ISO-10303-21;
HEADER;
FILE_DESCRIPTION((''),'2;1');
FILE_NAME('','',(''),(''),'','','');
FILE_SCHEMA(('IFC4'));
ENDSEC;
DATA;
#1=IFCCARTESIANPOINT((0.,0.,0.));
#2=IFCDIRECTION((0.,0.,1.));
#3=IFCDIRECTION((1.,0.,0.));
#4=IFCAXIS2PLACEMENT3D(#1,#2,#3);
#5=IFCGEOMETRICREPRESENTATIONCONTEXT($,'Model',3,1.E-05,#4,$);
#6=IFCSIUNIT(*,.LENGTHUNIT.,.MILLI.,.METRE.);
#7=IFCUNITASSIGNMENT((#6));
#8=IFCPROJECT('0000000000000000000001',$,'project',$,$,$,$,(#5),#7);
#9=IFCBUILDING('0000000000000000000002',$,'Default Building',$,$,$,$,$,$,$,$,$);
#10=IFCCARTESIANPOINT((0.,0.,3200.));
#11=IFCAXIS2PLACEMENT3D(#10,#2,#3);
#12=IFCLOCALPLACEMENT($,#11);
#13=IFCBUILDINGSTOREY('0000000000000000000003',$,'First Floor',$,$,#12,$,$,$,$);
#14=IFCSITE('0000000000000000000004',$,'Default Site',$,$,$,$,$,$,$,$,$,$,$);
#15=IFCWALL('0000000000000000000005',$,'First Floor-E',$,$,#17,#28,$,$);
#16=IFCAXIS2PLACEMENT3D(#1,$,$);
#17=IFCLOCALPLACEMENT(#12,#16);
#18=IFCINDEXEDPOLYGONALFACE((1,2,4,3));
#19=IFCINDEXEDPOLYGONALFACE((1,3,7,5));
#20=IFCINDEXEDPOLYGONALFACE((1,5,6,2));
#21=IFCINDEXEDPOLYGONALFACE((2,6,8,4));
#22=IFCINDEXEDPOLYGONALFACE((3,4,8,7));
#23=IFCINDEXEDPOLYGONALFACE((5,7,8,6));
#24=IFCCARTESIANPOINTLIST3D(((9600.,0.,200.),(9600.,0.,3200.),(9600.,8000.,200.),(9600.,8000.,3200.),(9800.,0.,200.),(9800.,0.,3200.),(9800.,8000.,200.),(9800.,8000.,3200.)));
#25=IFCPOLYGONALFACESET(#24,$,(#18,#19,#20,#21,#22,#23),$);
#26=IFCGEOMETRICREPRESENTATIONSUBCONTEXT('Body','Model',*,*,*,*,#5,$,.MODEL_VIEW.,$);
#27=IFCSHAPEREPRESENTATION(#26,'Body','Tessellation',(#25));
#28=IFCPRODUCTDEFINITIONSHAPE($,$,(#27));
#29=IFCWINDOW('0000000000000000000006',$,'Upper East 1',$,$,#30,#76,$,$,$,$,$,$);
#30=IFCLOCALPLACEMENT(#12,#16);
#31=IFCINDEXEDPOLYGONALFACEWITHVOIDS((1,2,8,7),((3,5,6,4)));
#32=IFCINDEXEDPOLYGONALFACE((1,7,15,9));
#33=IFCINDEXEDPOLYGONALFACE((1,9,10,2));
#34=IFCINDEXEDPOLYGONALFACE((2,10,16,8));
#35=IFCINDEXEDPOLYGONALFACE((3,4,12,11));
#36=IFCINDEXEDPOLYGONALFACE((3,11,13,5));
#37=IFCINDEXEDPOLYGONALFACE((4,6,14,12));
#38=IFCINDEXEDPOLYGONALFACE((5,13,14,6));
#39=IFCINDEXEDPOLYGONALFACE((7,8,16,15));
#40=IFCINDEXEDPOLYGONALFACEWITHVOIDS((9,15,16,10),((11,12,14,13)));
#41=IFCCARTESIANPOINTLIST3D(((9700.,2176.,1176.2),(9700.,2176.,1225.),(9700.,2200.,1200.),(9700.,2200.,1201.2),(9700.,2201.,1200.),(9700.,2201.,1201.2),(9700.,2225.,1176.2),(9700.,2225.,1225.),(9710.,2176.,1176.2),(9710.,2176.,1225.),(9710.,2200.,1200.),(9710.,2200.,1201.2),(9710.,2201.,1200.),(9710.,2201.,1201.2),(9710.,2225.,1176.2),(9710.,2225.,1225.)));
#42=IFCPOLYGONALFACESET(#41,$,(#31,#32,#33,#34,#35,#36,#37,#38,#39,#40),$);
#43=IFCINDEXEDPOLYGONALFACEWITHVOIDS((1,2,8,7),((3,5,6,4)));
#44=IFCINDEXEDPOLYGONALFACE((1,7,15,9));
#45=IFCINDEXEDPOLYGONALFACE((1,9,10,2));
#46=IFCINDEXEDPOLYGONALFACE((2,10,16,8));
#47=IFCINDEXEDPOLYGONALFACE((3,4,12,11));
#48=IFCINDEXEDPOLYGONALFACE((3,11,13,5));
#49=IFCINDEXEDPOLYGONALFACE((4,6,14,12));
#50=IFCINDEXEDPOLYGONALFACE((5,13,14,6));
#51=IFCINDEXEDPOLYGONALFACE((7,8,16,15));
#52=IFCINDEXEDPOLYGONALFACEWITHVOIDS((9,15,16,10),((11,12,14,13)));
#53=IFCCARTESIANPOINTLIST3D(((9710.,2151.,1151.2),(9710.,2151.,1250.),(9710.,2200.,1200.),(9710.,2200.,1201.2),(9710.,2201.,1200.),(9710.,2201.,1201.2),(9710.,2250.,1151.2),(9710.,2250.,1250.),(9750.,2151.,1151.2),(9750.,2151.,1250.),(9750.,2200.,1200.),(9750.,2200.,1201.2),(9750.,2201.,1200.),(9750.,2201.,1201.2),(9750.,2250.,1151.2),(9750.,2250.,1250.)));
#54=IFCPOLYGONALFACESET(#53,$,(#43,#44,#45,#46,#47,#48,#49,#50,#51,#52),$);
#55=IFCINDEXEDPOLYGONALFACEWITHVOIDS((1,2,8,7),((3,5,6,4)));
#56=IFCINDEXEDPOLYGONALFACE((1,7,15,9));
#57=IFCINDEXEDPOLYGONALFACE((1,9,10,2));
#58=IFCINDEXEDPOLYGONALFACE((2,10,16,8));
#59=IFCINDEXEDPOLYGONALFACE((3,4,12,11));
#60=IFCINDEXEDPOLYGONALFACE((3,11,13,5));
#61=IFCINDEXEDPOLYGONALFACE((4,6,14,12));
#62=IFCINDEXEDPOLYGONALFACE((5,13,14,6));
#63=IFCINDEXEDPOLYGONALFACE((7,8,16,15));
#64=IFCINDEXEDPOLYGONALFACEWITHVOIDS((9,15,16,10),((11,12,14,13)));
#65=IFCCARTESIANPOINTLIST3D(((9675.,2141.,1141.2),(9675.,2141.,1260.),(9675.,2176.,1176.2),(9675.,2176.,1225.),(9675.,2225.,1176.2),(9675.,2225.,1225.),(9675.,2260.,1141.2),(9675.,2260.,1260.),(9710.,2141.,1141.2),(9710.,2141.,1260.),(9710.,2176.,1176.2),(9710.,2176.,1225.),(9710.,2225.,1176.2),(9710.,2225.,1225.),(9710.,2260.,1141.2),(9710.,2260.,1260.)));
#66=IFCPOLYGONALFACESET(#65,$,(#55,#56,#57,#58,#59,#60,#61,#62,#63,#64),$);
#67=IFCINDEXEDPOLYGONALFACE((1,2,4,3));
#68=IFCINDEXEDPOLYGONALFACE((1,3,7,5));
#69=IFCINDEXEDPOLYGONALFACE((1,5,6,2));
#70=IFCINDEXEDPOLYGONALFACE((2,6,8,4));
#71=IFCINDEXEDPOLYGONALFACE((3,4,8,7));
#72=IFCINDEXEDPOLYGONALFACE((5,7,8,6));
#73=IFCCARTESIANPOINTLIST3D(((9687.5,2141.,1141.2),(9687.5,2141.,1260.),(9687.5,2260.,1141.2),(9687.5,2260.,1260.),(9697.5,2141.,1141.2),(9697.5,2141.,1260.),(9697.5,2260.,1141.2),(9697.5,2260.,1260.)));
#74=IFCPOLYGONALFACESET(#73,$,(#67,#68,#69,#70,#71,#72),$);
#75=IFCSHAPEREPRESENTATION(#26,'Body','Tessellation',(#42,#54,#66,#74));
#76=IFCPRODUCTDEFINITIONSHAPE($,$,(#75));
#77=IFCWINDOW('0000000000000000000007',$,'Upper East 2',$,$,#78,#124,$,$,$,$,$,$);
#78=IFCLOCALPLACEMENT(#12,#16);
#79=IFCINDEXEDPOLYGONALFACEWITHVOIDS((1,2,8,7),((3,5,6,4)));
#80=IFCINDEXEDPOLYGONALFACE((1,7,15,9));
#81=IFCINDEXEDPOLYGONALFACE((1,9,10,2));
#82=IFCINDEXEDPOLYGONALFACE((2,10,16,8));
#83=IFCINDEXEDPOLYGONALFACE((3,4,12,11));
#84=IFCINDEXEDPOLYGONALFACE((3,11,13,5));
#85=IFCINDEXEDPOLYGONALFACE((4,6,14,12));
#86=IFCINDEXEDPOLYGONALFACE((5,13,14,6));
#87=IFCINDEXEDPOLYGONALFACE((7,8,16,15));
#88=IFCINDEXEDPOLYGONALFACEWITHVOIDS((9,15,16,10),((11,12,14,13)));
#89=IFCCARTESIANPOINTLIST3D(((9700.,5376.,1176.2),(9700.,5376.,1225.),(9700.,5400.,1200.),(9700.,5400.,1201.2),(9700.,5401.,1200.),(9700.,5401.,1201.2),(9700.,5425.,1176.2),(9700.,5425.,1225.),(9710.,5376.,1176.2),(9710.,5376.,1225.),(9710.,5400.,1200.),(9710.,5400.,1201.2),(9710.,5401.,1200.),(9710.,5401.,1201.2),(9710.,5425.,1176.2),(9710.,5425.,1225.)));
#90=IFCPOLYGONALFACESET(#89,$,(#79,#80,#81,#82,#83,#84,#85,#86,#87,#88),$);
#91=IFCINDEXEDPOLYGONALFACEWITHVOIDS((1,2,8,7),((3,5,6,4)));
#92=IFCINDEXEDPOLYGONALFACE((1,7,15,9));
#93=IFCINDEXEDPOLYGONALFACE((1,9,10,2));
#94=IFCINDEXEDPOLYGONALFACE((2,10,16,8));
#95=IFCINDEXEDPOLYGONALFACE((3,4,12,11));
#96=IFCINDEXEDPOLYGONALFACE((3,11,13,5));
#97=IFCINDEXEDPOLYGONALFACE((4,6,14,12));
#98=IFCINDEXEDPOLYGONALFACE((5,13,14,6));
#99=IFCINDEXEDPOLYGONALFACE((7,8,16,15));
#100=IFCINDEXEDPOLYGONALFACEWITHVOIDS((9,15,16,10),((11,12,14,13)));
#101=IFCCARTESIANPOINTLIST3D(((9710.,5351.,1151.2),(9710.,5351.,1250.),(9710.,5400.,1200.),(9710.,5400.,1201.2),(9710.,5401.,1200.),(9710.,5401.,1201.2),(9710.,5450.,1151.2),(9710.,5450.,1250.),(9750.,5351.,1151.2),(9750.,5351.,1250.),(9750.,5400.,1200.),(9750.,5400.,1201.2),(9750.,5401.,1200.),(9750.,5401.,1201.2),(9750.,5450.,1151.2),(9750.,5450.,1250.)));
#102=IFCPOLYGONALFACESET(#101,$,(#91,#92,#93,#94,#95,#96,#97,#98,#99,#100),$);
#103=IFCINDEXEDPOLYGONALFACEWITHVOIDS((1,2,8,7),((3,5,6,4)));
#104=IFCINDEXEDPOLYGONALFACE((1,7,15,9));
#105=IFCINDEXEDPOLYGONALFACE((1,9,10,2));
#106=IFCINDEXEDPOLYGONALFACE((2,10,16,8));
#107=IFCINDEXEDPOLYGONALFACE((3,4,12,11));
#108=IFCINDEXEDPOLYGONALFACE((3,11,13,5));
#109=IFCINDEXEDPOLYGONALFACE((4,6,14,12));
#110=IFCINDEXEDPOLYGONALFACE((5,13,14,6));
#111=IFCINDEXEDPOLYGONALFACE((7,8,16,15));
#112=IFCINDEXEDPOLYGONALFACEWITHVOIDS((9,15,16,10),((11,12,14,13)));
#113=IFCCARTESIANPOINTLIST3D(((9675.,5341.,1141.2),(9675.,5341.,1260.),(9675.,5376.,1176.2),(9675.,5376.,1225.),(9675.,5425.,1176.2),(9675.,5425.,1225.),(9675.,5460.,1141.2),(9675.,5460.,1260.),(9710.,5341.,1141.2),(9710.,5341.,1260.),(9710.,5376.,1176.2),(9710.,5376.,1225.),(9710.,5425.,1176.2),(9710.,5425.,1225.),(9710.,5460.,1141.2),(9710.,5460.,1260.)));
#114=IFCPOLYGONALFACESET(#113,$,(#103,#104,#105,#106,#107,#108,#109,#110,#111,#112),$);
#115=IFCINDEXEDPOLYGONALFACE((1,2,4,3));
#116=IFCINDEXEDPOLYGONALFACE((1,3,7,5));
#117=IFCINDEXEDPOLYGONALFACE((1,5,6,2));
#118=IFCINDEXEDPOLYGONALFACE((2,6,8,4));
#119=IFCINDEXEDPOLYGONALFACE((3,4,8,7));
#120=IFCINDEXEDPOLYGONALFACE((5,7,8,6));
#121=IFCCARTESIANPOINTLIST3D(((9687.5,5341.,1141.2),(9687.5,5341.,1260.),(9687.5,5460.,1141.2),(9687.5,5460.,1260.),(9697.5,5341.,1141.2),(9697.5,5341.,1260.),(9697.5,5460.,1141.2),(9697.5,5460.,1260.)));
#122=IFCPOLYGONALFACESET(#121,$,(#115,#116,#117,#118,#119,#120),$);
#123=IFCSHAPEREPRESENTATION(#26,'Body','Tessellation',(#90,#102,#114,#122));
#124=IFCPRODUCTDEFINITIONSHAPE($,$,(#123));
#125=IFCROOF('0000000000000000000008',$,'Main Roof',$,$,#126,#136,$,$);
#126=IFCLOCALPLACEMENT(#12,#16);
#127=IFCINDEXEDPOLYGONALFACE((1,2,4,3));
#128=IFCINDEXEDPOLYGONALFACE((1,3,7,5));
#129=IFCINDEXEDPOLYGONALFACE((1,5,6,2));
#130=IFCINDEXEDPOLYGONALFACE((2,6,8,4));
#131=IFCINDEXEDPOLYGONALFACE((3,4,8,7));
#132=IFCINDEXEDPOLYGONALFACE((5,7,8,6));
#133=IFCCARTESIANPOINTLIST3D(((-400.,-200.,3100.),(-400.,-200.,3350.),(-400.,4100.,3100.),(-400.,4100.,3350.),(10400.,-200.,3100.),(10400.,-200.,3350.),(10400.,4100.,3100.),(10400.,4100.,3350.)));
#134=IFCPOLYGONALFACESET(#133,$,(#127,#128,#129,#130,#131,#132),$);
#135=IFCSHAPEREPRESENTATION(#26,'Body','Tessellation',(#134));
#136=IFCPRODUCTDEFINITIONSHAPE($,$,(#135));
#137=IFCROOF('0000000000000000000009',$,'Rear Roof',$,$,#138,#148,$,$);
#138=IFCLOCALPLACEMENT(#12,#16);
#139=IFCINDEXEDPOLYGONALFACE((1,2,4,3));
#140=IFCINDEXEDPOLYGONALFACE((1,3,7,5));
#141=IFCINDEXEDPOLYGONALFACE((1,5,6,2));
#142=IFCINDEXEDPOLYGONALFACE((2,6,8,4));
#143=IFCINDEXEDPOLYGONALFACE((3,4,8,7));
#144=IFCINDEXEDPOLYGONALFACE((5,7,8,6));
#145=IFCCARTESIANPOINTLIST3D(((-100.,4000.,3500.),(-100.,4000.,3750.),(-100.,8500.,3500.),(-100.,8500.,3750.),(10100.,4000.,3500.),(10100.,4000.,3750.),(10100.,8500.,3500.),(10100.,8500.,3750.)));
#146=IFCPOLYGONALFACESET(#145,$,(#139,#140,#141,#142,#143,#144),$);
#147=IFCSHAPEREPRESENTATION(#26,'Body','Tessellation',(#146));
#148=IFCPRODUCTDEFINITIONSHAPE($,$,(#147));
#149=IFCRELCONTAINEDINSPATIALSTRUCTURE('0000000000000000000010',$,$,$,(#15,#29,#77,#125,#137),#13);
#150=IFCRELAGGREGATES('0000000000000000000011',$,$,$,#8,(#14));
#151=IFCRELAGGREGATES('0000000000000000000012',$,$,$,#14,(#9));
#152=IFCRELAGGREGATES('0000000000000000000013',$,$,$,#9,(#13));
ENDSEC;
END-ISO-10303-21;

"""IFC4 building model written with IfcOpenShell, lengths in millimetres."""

from ifc_helpers import new_model, si_unit, frame, origin_with_axes, place, context, subcontext, project, spatial, line, indexed_curve, outline, extrude, element, fill, save


model = new_model("IFC4")

# Units and contexts
model_context = context("Model", 3, precision=1e-05, world=origin_with_axes())
body_context = subcontext(model_context, "Body", "Model", "MODEL_VIEW")
ifc_project = project(units=[si_unit("LENGTHUNIT", "METRE", prefix="MILLI")], contexts=[model_context])

# Site, building, storey
site = spatial("IfcSite", under=ifc_project, Name="Default Site")
building = spatial("IfcBuilding", under=site, Name="Default Building")
storey_placement = place(None, frame((0.0, 0.0, 3200.0), z_axis=(0.0, 0.0, 1.0), x_axis=(1.0, 0.0, 0.0)))
storey = spatial("IfcBuildingStorey", under=building, at=storey_placement, Name="First Floor")

# Wall, openings, windows
wall_1_placement = place(storey_placement, frame((0.0, 0.0, 200.0), z_axis=(0.0, 0.0, 1.0), x_axis=(1.0, 0.0, 0.0)))
wall_1 = element("IfcWall", 1, at=wall_1_placement, inside=storey, Name="First Floor-E", context=body_context, shape_type="SweptSolid", body=[
    extrude(outline(indexed_curve([(9800.0, 0.0), (9800.0, 8000.0), (9600.0, 8000.0), (9600.0, 0.0), (9800.0, 0.0)])), None, (0.0, 0.0, 1.0), 3000.0),
])
opening_1_placement = place(wall_1_placement, frame((0.0, 0.0, 1000.0), z_axis=(0.0, 0.0, 1.0), x_axis=(1.0, 0.0, 0.0)))
opening_1 = element("IfcOpeningElement", 2, at=opening_1_placement, cuts=wall_1, context=body_context, shape_type="SweptSolid", body=[
    extrude(outline(indexed_curve([(9800.0, 2200.0), (10000.0, 2200.0), (10000.0, 3200.0), (9800.0, 3200.0), (9800.0, 2200.0)])), None, (0.0, 0.0, 1.0), 1200.0),
])
opening_2_placement = place(wall_1_placement, frame((0.0, 0.0, 1000.0), z_axis=(0.0, 0.0, 1.0), x_axis=(1.0, 0.0, 0.0)))
opening_2 = element("IfcOpeningElement", 3, at=opening_2_placement, cuts=wall_1, context=body_context, shape_type="SweptSolid", body=[
    extrude(outline(indexed_curve([(9800.0, 5400.0), (10000.0, 5400.0), (10000.0, 6400.0), (9800.0, 6400.0), (9800.0, 5400.0)])), None, (0.0, 0.0, 1.0), 1200.0),
])
window_1_placement = place(storey_placement, frame((9800.0, 2200.0, 1200.0), z_axis=(0.0, 0.0, 1.0), x_axis=(0.0, 1.0, 0.0)))
window_1 = element("IfcWindow", 4, at=window_1_placement, inside=storey, Name="Upper East 1", context=body_context, shape_type="SweptSolid", body=[
    extrude(outline(indexed_curve([(0.0, 0.0), (1.0, 0.0), (1.0, 1.2), (0.0, 1.2)], segments=[line(1, 2, 3, 4, 1)]), holes=[indexed_curve([(25.0, 25.0), (-24.0, 25.0), (-24.0, -23.8), (25.0, -23.8)], segments=[line(1, 2, 3, 4, 1)])]), frame((0.0, 90.0, 0.0), z_axis=(0.0, -1.0, 0.0), x_axis=(1.0, 0.0, 0.0)), (0.0, 0.0, -1.0), 10.0),
    extrude(outline(indexed_curve([(0.0, 0.0), (1.0, 0.0), (1.0, 1.2), (0.0, 1.2)], segments=[line(1, 2, 3, 4, 1)]), holes=[indexed_curve([(50.0, 50.0), (-49.0, 50.0), (-49.0, -48.8), (50.0, -48.8)], segments=[line(1, 2, 3, 4, 1)])]), frame((0.0, 50.0, 0.0), z_axis=(0.0, -1.0, 0.0), x_axis=(1.0, 0.0, 0.0)), (0.0, 0.0, -1.0), 40.0),
    extrude(outline(indexed_curve([(0.0, 0.0), (-49.0, 0.0), (-49.0, -48.8), (0.0, -48.8)], segments=[line(1, 2, 3, 4, 1)]), holes=[indexed_curve([(35.0, 35.0), (-84.0, 35.0), (-84.0, -83.8), (35.0, -83.8)], segments=[line(1, 2, 3, 4, 1)])]), frame((25.0, 90.0, 25.0), z_axis=(0.0, -1.0, 0.0), x_axis=(1.0, 0.0, 0.0)), (0.0, 0.0, -1.0), 35.0),
    extrude(outline(indexed_curve([(35.0, 35.0), (-84.0, 35.0), (-84.0, -83.8), (35.0, -83.8)], segments=[line(1, 2, 3, 4, 1)])), frame((25.0, 102.5, 25.0), z_axis=(0.0, -1.0, 0.0), x_axis=(1.0, 0.0, 0.0)), (0.0, 0.0, -1.0), 10.0),
])
fill(opening_1, window_1)
window_2_placement = place(storey_placement, frame((9800.0, 5400.0, 1200.0), z_axis=(0.0, 0.0, 1.0), x_axis=(0.0, 1.0, 0.0)))
window_2 = element("IfcWindow", 5, at=window_2_placement, inside=storey, Name="Upper East 2", context=body_context, shape_type="SweptSolid", body=[
    extrude(outline(indexed_curve([(0.0, 0.0), (1.0, 0.0), (1.0, 1.2), (0.0, 1.2)], segments=[line(1, 2, 3, 4, 1)]), holes=[indexed_curve([(25.0, 25.0), (-24.0, 25.0), (-24.0, -23.8), (25.0, -23.8)], segments=[line(1, 2, 3, 4, 1)])]), frame((0.0, 90.0, 0.0), z_axis=(0.0, -1.0, 0.0), x_axis=(1.0, 0.0, 0.0)), (0.0, 0.0, -1.0), 10.0),
    extrude(outline(indexed_curve([(0.0, 0.0), (1.0, 0.0), (1.0, 1.2), (0.0, 1.2)], segments=[line(1, 2, 3, 4, 1)]), holes=[indexed_curve([(50.0, 50.0), (-49.0, 50.0), (-49.0, -48.8), (50.0, -48.8)], segments=[line(1, 2, 3, 4, 1)])]), frame((0.0, 50.0, 0.0), z_axis=(0.0, -1.0, 0.0), x_axis=(1.0, 0.0, 0.0)), (0.0, 0.0, -1.0), 40.0),
    extrude(outline(indexed_curve([(0.0, 0.0), (-49.0, 0.0), (-49.0, -48.8), (0.0, -48.8)], segments=[line(1, 2, 3, 4, 1)]), holes=[indexed_curve([(35.0, 35.0), (-84.0, 35.0), (-84.0, -83.8), (35.0, -83.8)], segments=[line(1, 2, 3, 4, 1)])]), frame((25.0, 90.0, 25.0), z_axis=(0.0, -1.0, 0.0), x_axis=(1.0, 0.0, 0.0)), (0.0, 0.0, -1.0), 35.0),
    extrude(outline(indexed_curve([(35.0, 35.0), (-84.0, 35.0), (-84.0, -83.8), (35.0, -83.8)], segments=[line(1, 2, 3, 4, 1)])), frame((25.0, 102.5, 25.0), z_axis=(0.0, -1.0, 0.0), x_axis=(1.0, 0.0, 0.0)), (0.0, 0.0, -1.0), 10.0),
])
fill(opening_2, window_2)

# Roofs
roof_1_placement = place(storey_placement, frame((0.0, 0.0, 3100.0), z_axis=(0.0, 0.0, 1.0), x_axis=(1.0, 0.0, 0.0)))
element("IfcRoof", 6, at=roof_1_placement, inside=storey, Name="Main Roof", context=body_context, shape_type="SweptSolid", body=[
    extrude(outline(indexed_curve([(-400.0, -200.0), (10400.0, -200.0), (10400.0, 4100.0), (-400.0, 4100.0), (-400.0, -200.0)])), None, (0.0, 0.0, 1.0), 250.0),
])
roof_2_placement = place(storey_placement, frame((0.0, 0.0, 3500.0), z_axis=(0.0, 0.0, 1.0), x_axis=(1.0, 0.0, 0.0)))
element("IfcRoof", 7, at=roof_2_placement, inside=storey, Name="Rear Roof", context=body_context, shape_type="SweptSolid", body=[
    extrude(outline(indexed_curve([(-100.0, 4000.0), (10100.0, 4000.0), (10100.0, 8500.0), (-100.0, 8500.0), (-100.0, 4000.0)])), None, (0.0, 0.0, 1.0), 250.0),
])

save(model, "model.ifc")
